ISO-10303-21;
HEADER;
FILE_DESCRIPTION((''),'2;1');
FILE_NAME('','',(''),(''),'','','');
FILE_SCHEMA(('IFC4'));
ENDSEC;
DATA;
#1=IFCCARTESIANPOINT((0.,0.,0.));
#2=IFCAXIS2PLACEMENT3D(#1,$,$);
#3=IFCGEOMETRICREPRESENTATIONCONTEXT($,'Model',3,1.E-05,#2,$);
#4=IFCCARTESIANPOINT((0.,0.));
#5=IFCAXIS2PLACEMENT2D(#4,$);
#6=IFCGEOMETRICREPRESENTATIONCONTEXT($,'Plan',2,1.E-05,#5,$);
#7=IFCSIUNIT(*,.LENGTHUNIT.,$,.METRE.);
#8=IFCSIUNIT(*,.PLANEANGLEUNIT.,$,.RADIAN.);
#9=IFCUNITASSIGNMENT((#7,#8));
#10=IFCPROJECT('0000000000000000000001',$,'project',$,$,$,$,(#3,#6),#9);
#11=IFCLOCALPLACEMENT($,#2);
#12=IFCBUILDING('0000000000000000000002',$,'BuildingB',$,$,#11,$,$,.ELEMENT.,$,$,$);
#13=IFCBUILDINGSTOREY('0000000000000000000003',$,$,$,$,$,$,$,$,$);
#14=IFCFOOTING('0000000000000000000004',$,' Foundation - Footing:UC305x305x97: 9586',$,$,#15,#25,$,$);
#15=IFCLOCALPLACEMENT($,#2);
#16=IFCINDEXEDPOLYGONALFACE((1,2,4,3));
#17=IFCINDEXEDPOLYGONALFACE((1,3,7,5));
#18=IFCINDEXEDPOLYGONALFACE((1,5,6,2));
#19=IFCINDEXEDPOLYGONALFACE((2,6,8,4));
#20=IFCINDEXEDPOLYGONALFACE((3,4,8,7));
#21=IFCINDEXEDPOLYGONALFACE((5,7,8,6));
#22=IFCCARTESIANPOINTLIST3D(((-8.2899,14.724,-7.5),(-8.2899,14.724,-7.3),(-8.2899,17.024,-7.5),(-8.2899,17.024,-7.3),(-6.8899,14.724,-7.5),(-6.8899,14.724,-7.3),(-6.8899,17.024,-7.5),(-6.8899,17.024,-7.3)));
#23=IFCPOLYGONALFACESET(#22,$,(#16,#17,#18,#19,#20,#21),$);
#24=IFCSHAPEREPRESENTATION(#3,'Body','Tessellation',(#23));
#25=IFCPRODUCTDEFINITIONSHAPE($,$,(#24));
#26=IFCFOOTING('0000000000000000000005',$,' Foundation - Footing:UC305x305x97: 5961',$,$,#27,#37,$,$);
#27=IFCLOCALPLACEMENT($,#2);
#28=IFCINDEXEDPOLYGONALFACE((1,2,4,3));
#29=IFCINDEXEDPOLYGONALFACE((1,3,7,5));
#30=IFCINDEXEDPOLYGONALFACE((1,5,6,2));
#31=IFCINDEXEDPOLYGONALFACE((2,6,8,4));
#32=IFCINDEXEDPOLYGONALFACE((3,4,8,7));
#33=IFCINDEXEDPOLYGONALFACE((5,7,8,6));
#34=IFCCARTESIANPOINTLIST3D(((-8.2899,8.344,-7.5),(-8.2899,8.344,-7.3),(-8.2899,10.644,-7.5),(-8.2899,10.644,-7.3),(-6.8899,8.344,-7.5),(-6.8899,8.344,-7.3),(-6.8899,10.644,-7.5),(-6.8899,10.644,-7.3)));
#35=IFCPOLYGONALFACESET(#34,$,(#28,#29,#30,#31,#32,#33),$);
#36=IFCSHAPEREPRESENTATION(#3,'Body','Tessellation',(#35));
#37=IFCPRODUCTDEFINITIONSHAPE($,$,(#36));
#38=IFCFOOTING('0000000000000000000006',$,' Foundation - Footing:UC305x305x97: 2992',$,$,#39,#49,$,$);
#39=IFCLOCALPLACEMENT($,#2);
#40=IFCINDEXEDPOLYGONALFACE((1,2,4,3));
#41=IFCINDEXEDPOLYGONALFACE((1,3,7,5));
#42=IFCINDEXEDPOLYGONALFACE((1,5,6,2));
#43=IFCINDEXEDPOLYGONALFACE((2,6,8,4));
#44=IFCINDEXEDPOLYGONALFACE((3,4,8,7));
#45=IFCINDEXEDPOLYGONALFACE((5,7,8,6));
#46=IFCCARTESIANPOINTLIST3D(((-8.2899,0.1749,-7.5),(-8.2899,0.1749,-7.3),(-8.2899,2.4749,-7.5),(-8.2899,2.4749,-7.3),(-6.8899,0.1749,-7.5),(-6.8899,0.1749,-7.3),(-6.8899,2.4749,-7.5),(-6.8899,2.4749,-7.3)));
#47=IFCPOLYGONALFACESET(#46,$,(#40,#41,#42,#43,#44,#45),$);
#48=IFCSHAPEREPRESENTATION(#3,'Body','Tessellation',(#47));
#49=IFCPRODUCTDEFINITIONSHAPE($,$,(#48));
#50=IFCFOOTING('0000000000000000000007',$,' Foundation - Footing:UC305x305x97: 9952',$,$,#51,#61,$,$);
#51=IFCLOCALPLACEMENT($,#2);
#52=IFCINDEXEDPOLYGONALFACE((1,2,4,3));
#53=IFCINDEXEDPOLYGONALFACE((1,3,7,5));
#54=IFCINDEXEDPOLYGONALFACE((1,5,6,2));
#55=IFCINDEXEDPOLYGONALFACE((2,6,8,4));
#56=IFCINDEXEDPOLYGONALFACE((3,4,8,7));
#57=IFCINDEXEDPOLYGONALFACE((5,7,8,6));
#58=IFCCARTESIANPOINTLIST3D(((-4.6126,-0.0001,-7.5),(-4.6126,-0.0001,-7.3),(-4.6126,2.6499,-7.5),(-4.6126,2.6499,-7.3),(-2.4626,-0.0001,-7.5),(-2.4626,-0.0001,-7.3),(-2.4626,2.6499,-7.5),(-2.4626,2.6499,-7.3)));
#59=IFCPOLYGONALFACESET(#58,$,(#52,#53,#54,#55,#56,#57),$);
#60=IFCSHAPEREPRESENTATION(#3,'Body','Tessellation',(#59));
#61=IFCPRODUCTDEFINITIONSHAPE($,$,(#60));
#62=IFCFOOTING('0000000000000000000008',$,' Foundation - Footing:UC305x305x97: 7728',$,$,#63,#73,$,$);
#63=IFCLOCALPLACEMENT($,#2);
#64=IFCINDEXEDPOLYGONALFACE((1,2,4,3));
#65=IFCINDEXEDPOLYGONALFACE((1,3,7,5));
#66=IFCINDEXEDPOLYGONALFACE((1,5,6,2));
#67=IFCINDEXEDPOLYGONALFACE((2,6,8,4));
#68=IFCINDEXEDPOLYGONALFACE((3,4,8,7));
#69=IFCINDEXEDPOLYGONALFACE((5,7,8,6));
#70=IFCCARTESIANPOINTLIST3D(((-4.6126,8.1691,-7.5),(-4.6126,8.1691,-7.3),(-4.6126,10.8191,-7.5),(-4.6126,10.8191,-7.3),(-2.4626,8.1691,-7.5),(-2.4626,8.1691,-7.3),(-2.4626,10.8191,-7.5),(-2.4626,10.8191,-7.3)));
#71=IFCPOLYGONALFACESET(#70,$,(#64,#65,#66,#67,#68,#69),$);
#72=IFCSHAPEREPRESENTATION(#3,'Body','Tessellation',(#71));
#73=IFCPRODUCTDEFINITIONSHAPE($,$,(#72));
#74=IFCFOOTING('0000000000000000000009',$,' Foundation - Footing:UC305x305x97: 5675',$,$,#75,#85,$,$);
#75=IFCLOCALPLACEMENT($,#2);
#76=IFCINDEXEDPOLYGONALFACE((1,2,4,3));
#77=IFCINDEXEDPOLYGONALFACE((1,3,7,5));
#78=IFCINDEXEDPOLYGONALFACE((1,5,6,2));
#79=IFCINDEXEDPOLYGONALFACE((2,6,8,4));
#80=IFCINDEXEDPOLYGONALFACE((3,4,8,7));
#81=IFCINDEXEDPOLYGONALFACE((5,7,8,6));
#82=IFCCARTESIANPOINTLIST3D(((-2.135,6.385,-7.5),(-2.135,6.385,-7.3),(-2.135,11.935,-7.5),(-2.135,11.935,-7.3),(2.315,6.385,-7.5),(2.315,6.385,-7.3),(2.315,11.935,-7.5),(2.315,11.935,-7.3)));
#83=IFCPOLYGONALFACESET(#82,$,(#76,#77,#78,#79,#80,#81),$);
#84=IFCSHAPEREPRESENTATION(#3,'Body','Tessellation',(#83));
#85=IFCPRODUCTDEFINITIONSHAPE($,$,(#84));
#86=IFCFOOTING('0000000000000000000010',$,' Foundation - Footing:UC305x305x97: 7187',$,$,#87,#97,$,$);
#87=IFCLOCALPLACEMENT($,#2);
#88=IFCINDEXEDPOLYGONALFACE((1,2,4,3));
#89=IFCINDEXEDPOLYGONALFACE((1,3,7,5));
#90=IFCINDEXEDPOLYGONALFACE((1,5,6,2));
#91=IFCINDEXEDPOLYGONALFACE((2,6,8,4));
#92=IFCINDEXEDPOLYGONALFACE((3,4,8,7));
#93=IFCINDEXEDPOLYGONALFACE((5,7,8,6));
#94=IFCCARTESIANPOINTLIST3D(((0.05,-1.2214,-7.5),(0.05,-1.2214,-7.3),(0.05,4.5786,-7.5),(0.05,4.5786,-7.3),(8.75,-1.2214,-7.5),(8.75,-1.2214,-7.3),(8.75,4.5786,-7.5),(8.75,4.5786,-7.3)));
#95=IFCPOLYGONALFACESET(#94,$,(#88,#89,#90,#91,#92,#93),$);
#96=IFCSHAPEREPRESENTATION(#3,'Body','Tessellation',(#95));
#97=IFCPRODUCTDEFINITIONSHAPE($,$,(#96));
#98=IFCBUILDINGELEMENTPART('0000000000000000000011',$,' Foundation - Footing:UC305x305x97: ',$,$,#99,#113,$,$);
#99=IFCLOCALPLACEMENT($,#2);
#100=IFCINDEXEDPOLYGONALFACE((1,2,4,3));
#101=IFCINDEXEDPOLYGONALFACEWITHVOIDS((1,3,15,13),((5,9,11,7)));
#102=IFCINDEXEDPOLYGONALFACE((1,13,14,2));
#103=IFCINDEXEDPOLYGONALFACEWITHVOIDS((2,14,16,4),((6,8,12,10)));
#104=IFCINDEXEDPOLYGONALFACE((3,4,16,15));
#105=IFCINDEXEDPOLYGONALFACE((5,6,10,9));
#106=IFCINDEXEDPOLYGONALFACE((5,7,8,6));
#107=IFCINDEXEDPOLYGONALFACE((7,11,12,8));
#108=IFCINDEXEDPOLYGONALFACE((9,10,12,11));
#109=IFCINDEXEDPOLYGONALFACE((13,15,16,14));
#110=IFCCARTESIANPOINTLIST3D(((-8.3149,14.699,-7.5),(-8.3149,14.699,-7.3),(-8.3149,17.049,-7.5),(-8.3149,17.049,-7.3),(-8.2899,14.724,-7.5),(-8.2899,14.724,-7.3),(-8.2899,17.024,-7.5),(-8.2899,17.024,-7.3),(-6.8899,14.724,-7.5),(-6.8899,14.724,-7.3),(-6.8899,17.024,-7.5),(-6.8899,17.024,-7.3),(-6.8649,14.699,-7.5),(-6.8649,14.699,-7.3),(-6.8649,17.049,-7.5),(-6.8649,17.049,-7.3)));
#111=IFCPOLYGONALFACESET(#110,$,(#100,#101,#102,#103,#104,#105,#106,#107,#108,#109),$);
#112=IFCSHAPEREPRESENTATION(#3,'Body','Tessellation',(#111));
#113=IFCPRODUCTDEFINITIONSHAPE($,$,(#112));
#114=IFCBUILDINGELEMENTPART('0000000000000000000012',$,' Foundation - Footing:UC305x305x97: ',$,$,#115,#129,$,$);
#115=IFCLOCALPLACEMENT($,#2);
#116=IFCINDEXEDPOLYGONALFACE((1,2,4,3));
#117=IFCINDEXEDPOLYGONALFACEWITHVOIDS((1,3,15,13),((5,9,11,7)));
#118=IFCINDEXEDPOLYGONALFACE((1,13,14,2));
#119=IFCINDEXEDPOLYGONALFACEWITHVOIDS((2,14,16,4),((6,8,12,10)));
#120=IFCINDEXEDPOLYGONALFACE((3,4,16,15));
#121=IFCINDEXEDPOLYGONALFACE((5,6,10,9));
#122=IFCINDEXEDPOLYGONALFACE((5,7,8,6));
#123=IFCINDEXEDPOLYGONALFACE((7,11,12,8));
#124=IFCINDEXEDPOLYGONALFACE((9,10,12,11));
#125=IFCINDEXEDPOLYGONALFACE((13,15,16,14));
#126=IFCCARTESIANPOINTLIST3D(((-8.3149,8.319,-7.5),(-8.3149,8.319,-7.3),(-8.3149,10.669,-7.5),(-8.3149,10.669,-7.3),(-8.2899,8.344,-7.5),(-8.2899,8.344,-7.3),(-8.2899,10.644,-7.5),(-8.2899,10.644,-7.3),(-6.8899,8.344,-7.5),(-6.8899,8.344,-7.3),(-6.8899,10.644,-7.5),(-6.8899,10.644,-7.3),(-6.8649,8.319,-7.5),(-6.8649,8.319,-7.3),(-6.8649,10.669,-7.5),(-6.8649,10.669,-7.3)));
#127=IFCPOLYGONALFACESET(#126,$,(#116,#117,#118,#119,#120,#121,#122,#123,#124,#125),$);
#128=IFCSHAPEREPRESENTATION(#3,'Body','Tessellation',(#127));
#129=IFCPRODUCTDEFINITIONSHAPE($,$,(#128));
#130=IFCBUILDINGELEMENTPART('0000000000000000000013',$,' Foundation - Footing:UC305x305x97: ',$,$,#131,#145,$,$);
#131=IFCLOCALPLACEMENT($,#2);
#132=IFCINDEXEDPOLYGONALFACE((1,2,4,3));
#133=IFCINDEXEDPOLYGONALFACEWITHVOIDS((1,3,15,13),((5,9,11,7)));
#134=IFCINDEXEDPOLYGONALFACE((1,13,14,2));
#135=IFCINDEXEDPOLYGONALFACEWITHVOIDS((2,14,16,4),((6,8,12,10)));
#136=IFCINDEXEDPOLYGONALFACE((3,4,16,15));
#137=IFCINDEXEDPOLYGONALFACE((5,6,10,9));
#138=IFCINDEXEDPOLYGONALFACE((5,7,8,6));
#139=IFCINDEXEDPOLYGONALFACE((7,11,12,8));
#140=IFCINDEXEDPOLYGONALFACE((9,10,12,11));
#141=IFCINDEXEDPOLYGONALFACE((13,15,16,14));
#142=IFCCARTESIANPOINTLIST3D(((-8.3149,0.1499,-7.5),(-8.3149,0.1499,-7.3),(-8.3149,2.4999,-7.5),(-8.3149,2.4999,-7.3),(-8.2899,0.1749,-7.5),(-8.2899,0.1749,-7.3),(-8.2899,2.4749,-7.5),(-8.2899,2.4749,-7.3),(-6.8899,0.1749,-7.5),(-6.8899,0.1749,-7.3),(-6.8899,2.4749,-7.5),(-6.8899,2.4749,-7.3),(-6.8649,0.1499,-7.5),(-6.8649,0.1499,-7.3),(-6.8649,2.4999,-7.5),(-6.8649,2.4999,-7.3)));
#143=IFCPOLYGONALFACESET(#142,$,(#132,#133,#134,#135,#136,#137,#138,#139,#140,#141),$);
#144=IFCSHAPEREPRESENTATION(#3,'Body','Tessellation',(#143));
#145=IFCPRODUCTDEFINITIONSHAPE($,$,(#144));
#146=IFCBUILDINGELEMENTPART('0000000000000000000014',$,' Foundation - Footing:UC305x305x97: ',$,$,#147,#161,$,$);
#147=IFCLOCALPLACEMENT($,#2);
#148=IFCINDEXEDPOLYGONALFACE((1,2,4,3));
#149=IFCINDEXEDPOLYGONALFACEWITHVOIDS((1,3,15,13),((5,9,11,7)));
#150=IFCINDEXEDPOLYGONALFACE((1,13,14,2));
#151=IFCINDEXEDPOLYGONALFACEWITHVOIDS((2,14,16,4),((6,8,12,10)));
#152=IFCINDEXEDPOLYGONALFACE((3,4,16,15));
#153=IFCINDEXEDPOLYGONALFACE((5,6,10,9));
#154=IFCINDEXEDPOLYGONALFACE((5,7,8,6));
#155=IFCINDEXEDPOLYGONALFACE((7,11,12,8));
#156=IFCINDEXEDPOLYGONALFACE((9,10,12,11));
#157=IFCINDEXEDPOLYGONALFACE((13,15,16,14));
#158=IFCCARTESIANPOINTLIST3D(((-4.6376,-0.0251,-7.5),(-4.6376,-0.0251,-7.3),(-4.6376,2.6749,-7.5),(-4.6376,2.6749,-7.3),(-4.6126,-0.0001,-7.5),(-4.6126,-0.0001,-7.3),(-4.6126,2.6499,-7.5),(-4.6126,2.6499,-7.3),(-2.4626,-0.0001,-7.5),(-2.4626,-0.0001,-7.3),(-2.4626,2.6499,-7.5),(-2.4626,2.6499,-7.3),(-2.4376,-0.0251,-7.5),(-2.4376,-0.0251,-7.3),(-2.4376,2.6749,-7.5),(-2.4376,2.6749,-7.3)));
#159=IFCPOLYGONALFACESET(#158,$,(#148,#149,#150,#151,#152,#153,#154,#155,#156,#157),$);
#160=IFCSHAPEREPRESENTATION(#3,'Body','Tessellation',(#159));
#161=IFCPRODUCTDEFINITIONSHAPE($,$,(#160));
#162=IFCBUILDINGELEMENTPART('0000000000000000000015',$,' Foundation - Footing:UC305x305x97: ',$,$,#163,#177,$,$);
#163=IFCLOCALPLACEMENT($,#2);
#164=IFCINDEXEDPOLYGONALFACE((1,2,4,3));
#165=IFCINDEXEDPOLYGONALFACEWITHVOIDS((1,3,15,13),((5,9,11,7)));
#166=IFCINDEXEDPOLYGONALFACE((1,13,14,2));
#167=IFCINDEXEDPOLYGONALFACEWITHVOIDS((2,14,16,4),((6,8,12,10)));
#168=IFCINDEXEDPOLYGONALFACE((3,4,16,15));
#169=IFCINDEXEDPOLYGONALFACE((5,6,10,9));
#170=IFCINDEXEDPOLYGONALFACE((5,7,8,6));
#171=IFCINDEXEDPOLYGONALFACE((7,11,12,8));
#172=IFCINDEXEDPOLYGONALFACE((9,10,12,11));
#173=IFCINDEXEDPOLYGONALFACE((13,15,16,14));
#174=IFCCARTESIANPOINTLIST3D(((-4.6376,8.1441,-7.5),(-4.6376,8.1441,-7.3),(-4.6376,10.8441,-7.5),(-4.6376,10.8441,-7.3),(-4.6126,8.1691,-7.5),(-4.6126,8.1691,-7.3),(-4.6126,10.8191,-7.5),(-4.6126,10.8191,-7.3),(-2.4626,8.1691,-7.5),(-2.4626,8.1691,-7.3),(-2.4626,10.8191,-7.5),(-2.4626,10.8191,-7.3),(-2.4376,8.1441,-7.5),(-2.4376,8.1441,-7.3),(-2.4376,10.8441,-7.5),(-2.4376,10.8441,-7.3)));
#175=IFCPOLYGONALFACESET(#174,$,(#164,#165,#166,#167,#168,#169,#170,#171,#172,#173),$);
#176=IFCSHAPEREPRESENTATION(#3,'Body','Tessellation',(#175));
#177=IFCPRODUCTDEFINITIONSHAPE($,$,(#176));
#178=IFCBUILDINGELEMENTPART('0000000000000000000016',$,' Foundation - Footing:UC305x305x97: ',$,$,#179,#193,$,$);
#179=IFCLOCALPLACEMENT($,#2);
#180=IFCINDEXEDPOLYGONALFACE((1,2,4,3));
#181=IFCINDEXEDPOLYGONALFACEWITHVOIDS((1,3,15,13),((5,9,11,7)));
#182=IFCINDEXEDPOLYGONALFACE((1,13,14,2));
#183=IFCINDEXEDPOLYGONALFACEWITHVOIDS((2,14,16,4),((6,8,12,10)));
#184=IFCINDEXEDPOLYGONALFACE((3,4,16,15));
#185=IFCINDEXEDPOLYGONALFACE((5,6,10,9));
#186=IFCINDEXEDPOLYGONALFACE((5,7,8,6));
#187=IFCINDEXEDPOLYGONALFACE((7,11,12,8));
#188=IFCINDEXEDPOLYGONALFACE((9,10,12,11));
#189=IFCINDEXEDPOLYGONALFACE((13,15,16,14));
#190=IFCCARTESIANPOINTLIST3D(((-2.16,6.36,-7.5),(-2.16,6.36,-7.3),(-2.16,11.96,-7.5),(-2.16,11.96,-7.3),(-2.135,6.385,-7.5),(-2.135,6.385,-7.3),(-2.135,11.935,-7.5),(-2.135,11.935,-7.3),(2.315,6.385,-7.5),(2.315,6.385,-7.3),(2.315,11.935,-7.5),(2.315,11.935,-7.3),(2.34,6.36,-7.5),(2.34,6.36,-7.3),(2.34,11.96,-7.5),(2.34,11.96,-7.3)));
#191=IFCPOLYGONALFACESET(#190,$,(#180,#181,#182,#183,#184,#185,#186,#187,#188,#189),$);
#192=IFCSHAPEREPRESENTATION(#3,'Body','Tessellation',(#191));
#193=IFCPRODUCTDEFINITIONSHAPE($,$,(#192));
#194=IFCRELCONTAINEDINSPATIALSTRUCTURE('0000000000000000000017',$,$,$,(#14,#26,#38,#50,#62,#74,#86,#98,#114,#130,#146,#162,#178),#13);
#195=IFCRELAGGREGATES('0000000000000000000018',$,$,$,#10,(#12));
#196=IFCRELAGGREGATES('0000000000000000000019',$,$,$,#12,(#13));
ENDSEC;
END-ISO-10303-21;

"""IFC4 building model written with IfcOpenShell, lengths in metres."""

from ifc_helpers import new_model, si_unit, origin, origin_2d, place, context, project, spatial, polyline, outline, extrude, element, save


model = new_model("IFC4")

# Units and contexts
model_context = context("Model", 3, precision=1e-05, world=origin())
plan_context = context("Plan", 2, precision=1e-05, world=origin_2d())
ifc_project = project(units=[si_unit("LENGTHUNIT", "METRE"), si_unit("PLANEANGLEUNIT", "RADIAN")], contexts=[model_context, plan_context])

# Building, storey
building_placement = place(None, origin())
building = spatial("IfcBuilding", under=ifc_project, at=building_placement, Name="BuildingB", CompositionType="ELEMENT")
storey = spatial("IfcBuildingStorey", under=building)

# Footings
element("IfcFooting", 1, inside=storey, Name=" Foundation - Footing:UC305x305x97: 9586", context=model_context, shape_type="SweptSolid", body=[
    extrude(outline(polyline([(-8.2899, 14.724, -7.5), (-6.8899, 14.724, -7.5), (-6.8899, 17.024, -7.5), (-8.2899, 17.024, -7.5), (-8.2899, 14.724, -7.5)])), None, (0.0, 0.0, 1.0), 0.2),
])
element("IfcFooting", 2, inside=storey, Name=" Foundation - Footing:UC305x305x97: 5961", context=model_context, shape_type="SweptSolid", body=[
    extrude(outline(polyline([(-8.2899, 8.344, -7.5), (-6.8899, 8.344, -7.5), (-6.8899, 10.644, -7.5), (-8.2899, 10.644, -7.5), (-8.2899, 8.344, -7.5)])), None, (0.0, 0.0, 1.0), 0.2),
])
element("IfcFooting", 3, inside=storey, Name=" Foundation - Footing:UC305x305x97: 2992", context=model_context, shape_type="SweptSolid", body=[
    extrude(outline(polyline([(-8.2899, 0.1749, -7.5), (-6.8899, 0.1749, -7.5), (-6.8899, 2.4749, -7.5), (-8.2899, 2.4749, -7.5), (-8.2899, 0.1749, -7.5)])), None, (0.0, 0.0, 1.0), 0.2),
])
element("IfcFooting", 4, inside=storey, Name=" Foundation - Footing:UC305x305x97: 9952", context=model_context, shape_type="SweptSolid", body=[
    extrude(outline(polyline([(-4.6126, -0.0001, -7.5), (-2.4626, -0.0001, -7.5), (-2.4626, 2.6499, -7.5), (-4.6126, 2.6499, -7.5), (-4.6126, -0.0001, -7.5)])), None, (0.0, 0.0, 1.0), 0.2),
])
element("IfcFooting", 5, inside=storey, Name=" Foundation - Footing:UC305x305x97: 7728", context=model_context, shape_type="SweptSolid", body=[
    extrude(outline(polyline([(-4.6126, 8.1691, -7.5), (-2.4626, 8.1691, -7.5), (-2.4626, 10.8191, -7.5), (-4.6126, 10.8191, -7.5), (-4.6126, 8.1691, -7.5)])), None, (0.0, 0.0, 1.0), 0.2),
])
element("IfcFooting", 6, inside=storey, Name=" Foundation - Footing:UC305x305x97: 5675", context=model_context, shape_type="SweptSolid", body=[
    extrude(outline(polyline([(-2.135, 6.385, -7.5), (2.315, 6.385, -7.5), (2.315, 11.935, -7.5), (-2.135, 11.935, -7.5), (-2.135, 6.385, -7.5)])), None, (0.0, 0.0, 1.0), 0.2),
])
element("IfcFooting", 7, inside=storey, Name=" Foundation - Footing:UC305x305x97: 7187", context=model_context, shape_type="SweptSolid", body=[
    extrude(outline(polyline([(0.05, -1.2214, -7.5), (8.75, -1.2214, -7.5), (8.75, 4.5786, -7.5), (0.05, 4.5786, -7.5), (0.05, -1.2214, -7.5)])), None, (0.0, 0.0, 1.0), 0.2),
])

# Building element parts, openings
building_element_part_1 = element("IfcBuildingElementPart", 8, inside=storey, Name=" Foundation - Footing:UC305x305x97: ", context=model_context, shape_type="SweptSolid", body=[
    extrude(outline(polyline([(-8.3149, 14.699, -7.5), (-6.8649, 14.699, -7.5), (-6.8649, 17.049, -7.5), (-8.3149, 17.049, -7.5), (-8.3149, 14.699, -7.5)])), None, (0.0, 0.0, 1.0), 0.2),
])
element("IfcOpeningElement", 9, inside=storey, cuts=building_element_part_1, context=model_context, shape_type="SweptSolid", body=[
    extrude(outline(polyline([(-8.2899, 14.724, -7.5), (-6.8899, 14.724, -7.5), (-6.8899, 17.024, -7.5), (-8.2899, 17.024, -7.5), (-8.2899, 14.724, -7.5)])), None, (0.0, 0.0, 1.0), 0.2),
])
building_element_part_2 = element("IfcBuildingElementPart", 10, inside=storey, Name=" Foundation - Footing:UC305x305x97: ", context=model_context, shape_type="SweptSolid", body=[
    extrude(outline(polyline([(-8.3149, 8.319, -7.5), (-6.8649, 8.319, -7.5), (-6.8649, 10.669, -7.5), (-8.3149, 10.669, -7.5), (-8.3149, 8.319, -7.5)])), None, (0.0, 0.0, 1.0), 0.2),
])
element("IfcOpeningElement", 11, inside=storey, cuts=building_element_part_2, context=model_context, shape_type="SweptSolid", body=[
    extrude(outline(polyline([(-8.2899, 8.344, -7.5), (-6.8899, 8.344, -7.5), (-6.8899, 10.644, -7.5), (-8.2899, 10.644, -7.5), (-8.2899, 8.344, -7.5)])), None, (0.0, 0.0, 1.0), 0.2),
])
building_element_part_3 = element("IfcBuildingElementPart", 12, inside=storey, Name=" Foundation - Footing:UC305x305x97: ", context=model_context, shape_type="SweptSolid", body=[
    extrude(outline(polyline([(-8.3149, 0.1499, -7.5), (-6.8649, 0.1499, -7.5), (-6.8649, 2.4999, -7.5), (-8.3149, 2.4999, -7.5), (-8.3149, 0.1499, -7.5)])), None, (0.0, 0.0, 1.0), 0.2),
])
element("IfcOpeningElement", 13, inside=storey, cuts=building_element_part_3, context=model_context, shape_type="SweptSolid", body=[
    extrude(outline(polyline([(-8.2899, 0.1749, -7.5), (-6.8899, 0.1749, -7.5), (-6.8899, 2.4749, -7.5), (-8.2899, 2.4749, -7.5), (-8.2899, 0.1749, -7.5)])), None, (0.0, 0.0, 1.0), 0.2),
])
building_element_part_4 = element("IfcBuildingElementPart", 14, inside=storey, Name=" Foundation - Footing:UC305x305x97: ", context=model_context, shape_type="SweptSolid", body=[
    extrude(outline(polyline([(-4.6376, -0.0251, -7.5), (-2.4376, -0.0251, -7.5), (-2.4376, 2.6749, -7.5), (-4.6376, 2.6749, -7.5), (-4.6376, -0.0251, -7.5)])), None, (0.0, 0.0, 1.0), 0.2),
])
element("IfcOpeningElement", 15, inside=storey, cuts=building_element_part_4, context=model_context, shape_type="SweptSolid", body=[
    extrude(outline(polyline([(-4.6126, -0.0001, -7.5), (-2.4626, -0.0001, -7.5), (-2.4626, 2.6499, -7.5), (-4.6126, 2.6499, -7.5), (-4.6126, -0.0001, -7.5)])), None, (0.0, 0.0, 1.0), 0.2),
])
building_element_part_5 = element("IfcBuildingElementPart", 16, inside=storey, Name=" Foundation - Footing:UC305x305x97: ", context=model_context, shape_type="SweptSolid", body=[
    extrude(outline(polyline([(-4.6376, 8.1441, -7.5), (-2.4376, 8.1441, -7.5), (-2.4376, 10.8441, -7.5), (-4.6376, 10.8441, -7.5), (-4.6376, 8.1441, -7.5)])), None, (0.0, 0.0, 1.0), 0.2),
])
element("IfcOpeningElement", 17, inside=storey, cuts=building_element_part_5, context=model_context, shape_type="SweptSolid", body=[
    extrude(outline(polyline([(-4.6126, 8.1691, -7.5), (-2.4626, 8.1691, -7.5), (-2.4626, 10.8191, -7.5), (-4.6126, 10.8191, -7.5), (-4.6126, 8.1691, -7.5)])), None, (0.0, 0.0, 1.0), 0.2),
])
building_element_part_6 = element("IfcBuildingElementPart", 18, inside=storey, Name=" Foundation - Footing:UC305x305x97: ", context=model_context, shape_type="SweptSolid", body=[
    extrude(outline(polyline([(-2.16, 6.36, -7.5), (2.34, 6.36, -7.5), (2.34, 11.96, -7.5), (-2.16, 11.96, -7.5), (-2.16, 6.36, -7.5)])), None, (0.0, 0.0, 1.0), 0.2),
])
element("IfcOpeningElement", 19, inside=storey, cuts=building_element_part_6, context=model_context, shape_type="SweptSolid", body=[
    extrude(outline(polyline([(-2.135, 6.385, -7.5), (2.315, 6.385, -7.5), (2.315, 11.935, -7.5), (-2.135, 11.935, -7.5), (-2.135, 6.385, -7.5)])), None, (0.0, 0.0, 1.0), 0.2),
])

save(model, "model.ifc")
